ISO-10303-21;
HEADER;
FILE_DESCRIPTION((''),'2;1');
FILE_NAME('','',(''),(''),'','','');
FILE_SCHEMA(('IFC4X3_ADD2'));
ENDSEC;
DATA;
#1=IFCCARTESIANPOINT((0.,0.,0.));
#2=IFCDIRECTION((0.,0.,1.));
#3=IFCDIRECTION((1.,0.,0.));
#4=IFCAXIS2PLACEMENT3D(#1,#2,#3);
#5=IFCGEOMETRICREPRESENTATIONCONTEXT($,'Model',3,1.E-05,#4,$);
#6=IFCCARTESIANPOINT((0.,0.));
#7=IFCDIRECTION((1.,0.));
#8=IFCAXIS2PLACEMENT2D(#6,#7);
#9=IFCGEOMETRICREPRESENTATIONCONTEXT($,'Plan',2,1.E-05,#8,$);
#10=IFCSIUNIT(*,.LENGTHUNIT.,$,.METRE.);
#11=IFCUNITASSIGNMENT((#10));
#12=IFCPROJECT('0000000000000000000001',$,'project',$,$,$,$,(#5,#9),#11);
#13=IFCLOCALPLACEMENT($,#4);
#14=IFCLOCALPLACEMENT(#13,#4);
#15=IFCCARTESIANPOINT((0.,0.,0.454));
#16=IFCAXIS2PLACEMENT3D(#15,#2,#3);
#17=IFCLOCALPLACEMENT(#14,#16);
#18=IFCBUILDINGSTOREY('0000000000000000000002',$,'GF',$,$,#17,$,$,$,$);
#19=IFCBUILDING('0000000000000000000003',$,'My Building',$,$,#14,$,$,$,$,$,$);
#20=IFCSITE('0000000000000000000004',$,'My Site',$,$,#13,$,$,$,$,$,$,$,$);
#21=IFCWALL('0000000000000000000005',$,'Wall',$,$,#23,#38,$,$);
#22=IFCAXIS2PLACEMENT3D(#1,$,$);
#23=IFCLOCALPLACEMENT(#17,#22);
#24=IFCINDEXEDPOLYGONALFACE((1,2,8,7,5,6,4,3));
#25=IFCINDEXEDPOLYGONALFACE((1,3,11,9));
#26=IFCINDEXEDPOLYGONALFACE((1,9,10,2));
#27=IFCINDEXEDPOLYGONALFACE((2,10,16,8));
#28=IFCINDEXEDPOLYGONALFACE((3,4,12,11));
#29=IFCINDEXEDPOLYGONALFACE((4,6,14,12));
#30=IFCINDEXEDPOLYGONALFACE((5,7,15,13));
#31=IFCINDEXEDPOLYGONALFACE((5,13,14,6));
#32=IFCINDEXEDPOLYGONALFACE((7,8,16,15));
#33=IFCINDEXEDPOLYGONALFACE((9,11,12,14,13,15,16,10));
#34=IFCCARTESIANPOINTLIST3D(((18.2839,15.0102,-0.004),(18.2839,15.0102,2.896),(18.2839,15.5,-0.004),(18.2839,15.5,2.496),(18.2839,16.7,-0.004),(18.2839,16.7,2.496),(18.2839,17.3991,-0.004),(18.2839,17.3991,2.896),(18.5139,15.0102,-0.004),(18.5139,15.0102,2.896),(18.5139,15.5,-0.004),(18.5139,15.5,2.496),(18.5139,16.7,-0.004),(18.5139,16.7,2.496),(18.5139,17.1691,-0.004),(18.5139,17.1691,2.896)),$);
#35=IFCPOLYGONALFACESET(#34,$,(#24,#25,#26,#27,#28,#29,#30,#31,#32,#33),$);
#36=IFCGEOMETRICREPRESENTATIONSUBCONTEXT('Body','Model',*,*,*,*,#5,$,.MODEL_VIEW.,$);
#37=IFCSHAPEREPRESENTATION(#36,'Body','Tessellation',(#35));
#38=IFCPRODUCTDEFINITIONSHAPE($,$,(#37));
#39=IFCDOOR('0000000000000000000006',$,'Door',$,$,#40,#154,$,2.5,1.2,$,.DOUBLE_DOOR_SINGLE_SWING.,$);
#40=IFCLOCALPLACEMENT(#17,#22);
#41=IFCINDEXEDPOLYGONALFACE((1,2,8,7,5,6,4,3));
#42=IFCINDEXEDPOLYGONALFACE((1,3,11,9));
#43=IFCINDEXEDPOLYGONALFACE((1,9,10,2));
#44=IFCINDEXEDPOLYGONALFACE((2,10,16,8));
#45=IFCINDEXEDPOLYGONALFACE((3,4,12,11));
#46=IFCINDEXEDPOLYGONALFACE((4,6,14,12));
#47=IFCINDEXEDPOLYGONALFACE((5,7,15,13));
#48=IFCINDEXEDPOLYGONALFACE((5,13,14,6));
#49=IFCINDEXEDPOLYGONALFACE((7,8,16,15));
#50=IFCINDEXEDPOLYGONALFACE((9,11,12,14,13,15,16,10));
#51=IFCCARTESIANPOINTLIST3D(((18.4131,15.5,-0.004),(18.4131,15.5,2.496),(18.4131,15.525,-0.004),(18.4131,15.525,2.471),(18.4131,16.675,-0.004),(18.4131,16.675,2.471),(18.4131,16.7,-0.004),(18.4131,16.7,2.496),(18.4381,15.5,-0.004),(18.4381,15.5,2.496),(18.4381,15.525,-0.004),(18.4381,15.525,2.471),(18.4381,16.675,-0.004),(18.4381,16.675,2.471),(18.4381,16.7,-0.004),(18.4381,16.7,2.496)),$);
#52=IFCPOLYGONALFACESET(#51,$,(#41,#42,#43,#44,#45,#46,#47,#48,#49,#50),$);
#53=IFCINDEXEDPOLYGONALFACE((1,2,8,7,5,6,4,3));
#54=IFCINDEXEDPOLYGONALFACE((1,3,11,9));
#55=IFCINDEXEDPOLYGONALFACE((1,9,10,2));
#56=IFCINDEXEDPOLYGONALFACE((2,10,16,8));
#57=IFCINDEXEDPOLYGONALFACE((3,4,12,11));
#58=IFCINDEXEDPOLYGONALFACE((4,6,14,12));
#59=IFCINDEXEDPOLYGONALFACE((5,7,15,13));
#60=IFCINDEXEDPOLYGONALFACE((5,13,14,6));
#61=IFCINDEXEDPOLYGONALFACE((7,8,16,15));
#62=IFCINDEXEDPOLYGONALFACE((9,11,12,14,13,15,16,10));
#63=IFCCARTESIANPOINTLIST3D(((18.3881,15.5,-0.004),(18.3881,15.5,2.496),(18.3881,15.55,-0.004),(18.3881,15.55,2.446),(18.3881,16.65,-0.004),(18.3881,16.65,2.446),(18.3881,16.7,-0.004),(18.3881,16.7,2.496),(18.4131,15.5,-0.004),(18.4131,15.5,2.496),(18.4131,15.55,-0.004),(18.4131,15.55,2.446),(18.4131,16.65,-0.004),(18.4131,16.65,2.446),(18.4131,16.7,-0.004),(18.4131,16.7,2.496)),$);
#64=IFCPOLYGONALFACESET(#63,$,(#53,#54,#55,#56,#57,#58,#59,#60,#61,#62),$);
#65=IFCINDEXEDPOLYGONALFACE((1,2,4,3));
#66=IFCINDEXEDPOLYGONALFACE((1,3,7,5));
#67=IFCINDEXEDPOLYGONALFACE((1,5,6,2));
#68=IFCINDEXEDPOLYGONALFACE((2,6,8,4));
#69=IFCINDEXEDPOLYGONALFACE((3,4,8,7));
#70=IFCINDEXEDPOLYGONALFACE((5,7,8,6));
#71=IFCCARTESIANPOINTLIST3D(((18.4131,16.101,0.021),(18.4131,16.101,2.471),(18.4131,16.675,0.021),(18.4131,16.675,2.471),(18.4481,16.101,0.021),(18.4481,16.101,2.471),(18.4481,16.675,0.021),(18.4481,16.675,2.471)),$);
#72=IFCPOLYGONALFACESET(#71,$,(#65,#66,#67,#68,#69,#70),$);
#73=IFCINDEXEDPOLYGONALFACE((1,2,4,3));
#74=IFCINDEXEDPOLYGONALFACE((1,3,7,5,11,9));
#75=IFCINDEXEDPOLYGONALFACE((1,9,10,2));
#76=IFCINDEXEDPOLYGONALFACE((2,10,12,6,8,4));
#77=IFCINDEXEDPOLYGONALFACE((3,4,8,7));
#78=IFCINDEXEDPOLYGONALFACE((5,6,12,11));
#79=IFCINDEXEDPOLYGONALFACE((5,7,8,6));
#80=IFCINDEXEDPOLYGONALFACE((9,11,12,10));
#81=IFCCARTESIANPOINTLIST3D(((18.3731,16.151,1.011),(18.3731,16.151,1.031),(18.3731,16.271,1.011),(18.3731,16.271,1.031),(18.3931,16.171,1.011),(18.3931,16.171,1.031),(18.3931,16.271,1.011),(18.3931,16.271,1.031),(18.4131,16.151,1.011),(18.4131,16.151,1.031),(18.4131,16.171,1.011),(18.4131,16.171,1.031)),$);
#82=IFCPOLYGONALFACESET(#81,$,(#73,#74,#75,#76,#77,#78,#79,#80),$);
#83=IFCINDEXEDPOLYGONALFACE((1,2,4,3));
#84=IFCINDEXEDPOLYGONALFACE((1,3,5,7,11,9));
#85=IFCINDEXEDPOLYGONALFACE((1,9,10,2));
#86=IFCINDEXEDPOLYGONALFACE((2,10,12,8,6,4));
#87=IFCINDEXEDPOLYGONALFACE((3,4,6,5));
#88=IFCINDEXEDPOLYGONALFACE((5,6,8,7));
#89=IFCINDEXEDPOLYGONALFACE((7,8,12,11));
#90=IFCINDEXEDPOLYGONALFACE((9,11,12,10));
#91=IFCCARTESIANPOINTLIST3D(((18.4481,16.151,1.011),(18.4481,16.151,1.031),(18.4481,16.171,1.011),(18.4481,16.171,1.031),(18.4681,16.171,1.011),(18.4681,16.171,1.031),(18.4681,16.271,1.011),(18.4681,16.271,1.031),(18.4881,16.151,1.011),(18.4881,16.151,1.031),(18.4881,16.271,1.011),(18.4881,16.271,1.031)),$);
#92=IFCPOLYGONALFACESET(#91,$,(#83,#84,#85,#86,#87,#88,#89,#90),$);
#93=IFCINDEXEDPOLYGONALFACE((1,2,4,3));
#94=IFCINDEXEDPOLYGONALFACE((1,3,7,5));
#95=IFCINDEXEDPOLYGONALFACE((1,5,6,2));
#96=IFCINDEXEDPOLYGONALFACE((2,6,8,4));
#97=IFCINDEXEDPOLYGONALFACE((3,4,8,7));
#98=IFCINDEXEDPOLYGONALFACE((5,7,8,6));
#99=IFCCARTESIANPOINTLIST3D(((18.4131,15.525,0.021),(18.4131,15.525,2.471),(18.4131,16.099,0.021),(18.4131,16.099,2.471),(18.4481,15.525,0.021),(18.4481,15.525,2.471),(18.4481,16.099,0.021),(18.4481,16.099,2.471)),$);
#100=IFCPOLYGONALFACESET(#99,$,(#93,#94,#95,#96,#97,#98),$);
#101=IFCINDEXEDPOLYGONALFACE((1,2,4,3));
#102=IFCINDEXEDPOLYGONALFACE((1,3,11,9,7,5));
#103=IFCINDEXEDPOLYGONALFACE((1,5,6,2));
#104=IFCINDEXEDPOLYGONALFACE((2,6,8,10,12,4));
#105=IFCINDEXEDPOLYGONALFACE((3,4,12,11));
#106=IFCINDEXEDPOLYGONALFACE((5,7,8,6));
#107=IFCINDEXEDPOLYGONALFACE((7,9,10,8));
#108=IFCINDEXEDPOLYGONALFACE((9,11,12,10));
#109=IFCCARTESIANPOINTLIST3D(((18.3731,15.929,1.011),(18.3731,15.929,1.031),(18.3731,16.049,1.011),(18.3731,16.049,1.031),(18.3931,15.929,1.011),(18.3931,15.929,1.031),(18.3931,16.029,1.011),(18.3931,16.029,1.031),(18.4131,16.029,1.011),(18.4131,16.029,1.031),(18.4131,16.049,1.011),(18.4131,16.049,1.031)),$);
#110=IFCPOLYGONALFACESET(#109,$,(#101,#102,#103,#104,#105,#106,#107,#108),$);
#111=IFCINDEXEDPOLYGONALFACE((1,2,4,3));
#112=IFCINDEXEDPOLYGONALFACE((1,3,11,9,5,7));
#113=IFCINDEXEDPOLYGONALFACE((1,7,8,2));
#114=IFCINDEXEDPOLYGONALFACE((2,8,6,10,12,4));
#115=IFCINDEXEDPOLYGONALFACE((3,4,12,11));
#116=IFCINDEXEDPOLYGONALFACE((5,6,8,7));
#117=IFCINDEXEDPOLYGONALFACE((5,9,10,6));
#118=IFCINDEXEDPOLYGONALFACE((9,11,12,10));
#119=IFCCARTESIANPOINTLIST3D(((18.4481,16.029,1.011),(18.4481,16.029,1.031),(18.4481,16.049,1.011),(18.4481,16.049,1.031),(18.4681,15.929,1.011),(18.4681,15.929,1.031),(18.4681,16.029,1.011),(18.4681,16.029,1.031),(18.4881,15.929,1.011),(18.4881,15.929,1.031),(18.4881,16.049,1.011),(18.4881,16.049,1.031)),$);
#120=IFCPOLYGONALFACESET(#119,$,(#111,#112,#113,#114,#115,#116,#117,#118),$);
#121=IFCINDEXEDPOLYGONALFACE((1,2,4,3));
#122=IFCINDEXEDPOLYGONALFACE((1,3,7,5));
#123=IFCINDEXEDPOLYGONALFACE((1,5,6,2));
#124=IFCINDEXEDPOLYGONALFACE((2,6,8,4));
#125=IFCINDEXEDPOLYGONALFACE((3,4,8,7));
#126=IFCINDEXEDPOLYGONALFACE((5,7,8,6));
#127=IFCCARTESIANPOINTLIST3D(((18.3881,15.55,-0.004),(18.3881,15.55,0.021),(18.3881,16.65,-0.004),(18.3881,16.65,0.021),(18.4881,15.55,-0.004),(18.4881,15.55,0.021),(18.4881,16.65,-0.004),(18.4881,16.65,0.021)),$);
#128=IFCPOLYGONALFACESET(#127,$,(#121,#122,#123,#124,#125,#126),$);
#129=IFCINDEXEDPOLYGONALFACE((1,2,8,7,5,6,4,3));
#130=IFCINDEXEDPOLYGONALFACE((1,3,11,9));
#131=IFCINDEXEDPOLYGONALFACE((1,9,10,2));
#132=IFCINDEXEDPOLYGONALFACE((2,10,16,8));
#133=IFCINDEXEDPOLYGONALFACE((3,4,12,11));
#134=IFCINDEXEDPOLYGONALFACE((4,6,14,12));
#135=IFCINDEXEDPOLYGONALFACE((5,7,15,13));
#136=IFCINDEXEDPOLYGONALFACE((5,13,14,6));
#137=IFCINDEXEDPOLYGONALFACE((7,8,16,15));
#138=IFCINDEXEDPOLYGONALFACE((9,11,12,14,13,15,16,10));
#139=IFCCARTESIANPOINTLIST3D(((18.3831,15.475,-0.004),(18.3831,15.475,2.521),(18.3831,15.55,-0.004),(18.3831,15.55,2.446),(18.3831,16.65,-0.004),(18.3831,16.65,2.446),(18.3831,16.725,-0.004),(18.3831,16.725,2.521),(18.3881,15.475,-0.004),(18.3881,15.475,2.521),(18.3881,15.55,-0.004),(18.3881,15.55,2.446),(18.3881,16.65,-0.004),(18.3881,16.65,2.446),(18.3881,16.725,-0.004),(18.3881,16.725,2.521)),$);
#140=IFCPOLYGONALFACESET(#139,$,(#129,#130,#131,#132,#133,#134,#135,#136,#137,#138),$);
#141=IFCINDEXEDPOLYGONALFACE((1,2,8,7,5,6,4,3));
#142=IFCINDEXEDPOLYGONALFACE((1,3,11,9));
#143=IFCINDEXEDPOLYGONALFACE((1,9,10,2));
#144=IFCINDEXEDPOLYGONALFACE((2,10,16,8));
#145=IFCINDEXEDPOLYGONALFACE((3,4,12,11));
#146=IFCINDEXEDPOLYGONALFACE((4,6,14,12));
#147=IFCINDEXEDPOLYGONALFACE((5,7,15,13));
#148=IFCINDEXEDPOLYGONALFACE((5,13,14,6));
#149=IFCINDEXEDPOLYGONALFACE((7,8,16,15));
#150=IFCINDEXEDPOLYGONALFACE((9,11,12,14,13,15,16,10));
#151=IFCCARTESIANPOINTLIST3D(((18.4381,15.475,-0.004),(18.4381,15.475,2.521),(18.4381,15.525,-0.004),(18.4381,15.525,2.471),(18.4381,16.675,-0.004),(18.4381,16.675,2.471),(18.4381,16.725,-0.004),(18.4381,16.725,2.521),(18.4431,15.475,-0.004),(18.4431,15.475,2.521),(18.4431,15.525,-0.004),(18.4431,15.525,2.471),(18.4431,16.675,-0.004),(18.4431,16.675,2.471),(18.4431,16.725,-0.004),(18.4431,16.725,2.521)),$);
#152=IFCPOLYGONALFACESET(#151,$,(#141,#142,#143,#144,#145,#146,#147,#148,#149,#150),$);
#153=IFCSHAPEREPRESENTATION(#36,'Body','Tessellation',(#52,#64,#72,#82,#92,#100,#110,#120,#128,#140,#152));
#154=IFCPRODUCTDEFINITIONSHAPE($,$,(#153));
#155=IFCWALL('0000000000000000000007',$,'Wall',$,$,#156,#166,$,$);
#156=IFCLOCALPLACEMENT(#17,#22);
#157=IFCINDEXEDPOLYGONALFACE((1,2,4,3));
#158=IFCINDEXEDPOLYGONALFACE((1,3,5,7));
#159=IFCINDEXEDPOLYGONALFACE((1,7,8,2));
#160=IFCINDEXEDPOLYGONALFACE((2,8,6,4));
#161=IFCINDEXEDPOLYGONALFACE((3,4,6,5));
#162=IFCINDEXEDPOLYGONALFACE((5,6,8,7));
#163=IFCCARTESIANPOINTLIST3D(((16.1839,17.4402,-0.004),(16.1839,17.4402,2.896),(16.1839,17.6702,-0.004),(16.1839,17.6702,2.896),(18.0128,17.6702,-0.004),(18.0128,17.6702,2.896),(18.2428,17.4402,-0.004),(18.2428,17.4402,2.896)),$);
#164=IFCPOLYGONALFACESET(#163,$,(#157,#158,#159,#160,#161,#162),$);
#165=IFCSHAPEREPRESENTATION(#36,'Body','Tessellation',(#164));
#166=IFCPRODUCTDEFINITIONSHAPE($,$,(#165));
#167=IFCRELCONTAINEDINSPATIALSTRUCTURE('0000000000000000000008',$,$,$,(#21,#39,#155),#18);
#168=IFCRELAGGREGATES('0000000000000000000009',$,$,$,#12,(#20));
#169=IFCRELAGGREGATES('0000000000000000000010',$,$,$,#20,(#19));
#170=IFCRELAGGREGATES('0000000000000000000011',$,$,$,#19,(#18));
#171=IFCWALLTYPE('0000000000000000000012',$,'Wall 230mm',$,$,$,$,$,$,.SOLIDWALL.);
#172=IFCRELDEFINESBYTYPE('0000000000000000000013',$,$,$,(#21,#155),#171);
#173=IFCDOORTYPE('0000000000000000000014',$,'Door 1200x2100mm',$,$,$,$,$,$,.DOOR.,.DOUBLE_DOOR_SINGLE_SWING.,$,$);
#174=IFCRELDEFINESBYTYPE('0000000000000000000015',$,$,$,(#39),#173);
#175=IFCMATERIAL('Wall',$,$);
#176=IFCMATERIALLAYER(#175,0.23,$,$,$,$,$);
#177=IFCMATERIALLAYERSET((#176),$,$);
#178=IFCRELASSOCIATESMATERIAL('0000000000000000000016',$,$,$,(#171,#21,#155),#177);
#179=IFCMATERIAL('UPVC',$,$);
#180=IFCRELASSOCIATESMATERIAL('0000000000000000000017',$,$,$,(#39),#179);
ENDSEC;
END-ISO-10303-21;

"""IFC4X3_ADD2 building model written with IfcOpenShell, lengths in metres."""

from ifc_helpers import new_model, entity, si_unit, frame, origin_with_axes, origin_2d_with_axis, place, context, subcontext, project, spatial, line, indexed_curve, outline, extrude, clip, halfspace, shape, source, transform, mapped, material, layer, layer_set, layer_usage, type_object, type_shapes, element, fill, save


model = new_model("IFC4X3_ADD2")

# Units and contexts
model_context = context("Model", 3, precision=1e-05, world=origin_with_axes())
plan_context = context("Plan", 2, precision=1e-05, world=origin_2d_with_axis())
body_context_1 = subcontext(model_context, "Body", "Model", "MODEL_VIEW")
body_context_2 = subcontext(plan_context, "Body", "Plan", "PLAN_VIEW")
ifc_project = project(units=[si_unit("LENGTHUNIT", "METRE")], contexts=[model_context, plan_context])

# Site, building, storey
site_placement = place(None, origin_with_axes())
site = spatial("IfcSite", under=ifc_project, at=site_placement, Name="My Site")
building_placement = place(site_placement, origin_with_axes())
building = spatial("IfcBuilding", under=site, at=building_placement, Name="My Building")
storey_placement = place(building_placement, frame((0.0, 0.0, 0.454), z_axis=(0.0, 0.0, 1.0), x_axis=(1.0, 0.0, 0.0)))
storey = spatial("IfcBuildingStorey", under=building, at=storey_placement, Name="GF")

# Shared definitions
ifc_material_1 = material(Name="UPVC")

# Shared definitions
ifc_material_2 = material(Name="Wall")

# Shared definitions
ifc_layer_1 = layer(ifc_material_2, 0.23)
ifc_layer_set_1 = layer_set([ifc_layer_1])
wall_type_1 = type_object("IfcWallType", Name="Wall 230mm", PredefinedType="SOLIDWALL", material=ifc_layer_set_1)

# Wall, opening, door
ifc_layer_usage_1 = layer_usage(ifc_layer_set_1, "AXIS2", "POSITIVE", 0.0)
wall_1_placement = place(storey_placement, frame((18.5139, 15.0102, -0.004), z_axis=(0.0, 0.0, 1.0), x_axis=(0.000001, 1.0, 0.0)))
wall_1 = element("IfcWall", 1, at=wall_1_placement, inside=storey, type_object=wall_type_1, material=ifc_layer_usage_1, Name="Wall", context=body_context_1, shape_type="Clipping", body=[
    clip(extrude(outline(indexed_curve([(0.0, 0.0), (0.0, 0.23), (2.3889, 0.23), (2.3889, 0.0), (0.0, 0.0)], self_intersect=False)), origin_with_axes(), (0.0, 0.0, 1.0), 2.9), halfspace(frame((2.1589, 0.0, -0.45), z_axis=(0.666999, -0.666993, 0.0), x_axis=(-0.707103, -0.70711, 0.0)), False)),
])
shared_shape_1 = source(origin_with_axes(), body_context_1, "Body", "SweptSolid", [
    extrude(outline(indexed_curve([(0.0, 0.0), (1.2, 0.0), (1.2, 2.5), (0.0, 2.5)], segments=[line(1, 2, 3, 4, 1)])), frame((0.0, -0.6, 0.0), z_axis=(0.0, -1.0, 0.0), x_axis=(1.0, 0.0, 0.0)), (0.0, 0.0, -1.0), 1.2),
])
opening_1_placement = place(wall_1_placement, frame((1.6898, 0.1258, 0.0), z_axis=(0.0, 0.0, 1.0), x_axis=(-1.0, 0.0, 0.0)))
opening_1 = element("IfcOpeningElement", 2, at=opening_1_placement, cuts=wall_1, PredefinedType="OPENING", context=body_context_1, shape_type="MappedRepresentation", body=[
    mapped(shared_shape_1, transform((0.0, 0.0, 0.0), x_axis=(1.0, 0.0, 0.0), y_axis=(0.0, 1.0, 0.0), z_axis=(0.0, 0.0, 1.0), scale=1.0)),
])
door_type_1 = type_object("IfcDoorType", Name="Door 1200x2100mm", OperationType="DOUBLE_DOOR_SINGLE_SWING", PredefinedType="DOOR")
shared_shape_2 = source(origin_with_axes(), body_context_1, "Body", "SweptSolid", [
    extrude(outline(indexed_curve([(0.0, 0.0), (0.0, 2.5), (1.2, 2.5), (1.2, 0.0), (1.175, 0.0), (1.175, 2.475), (0.025, 2.475), (0.025, 0.0)], segments=[line(1, 2, 3, 4, 5, 6, 7, 8, 1)])), frame((0.0, 0.025, 0.0), z_axis=(0.0, -1.0, 0.0), x_axis=(1.0, 0.0, 0.0)), (0.0, 0.0, -1.0), 0.025),
    extrude(outline(indexed_curve([(0.0, 0.0), (0.0, 2.5), (1.2, 2.5), (1.2, 0.0), (1.15, 0.0), (1.15, 2.45), (0.05, 2.45), (0.05, 0.0)], segments=[line(1, 2, 3, 4, 5, 6, 7, 8, 1)])), frame((0.0, 0.0, 0.0), z_axis=(0.0, -1.0, 0.0), x_axis=(1.0, 0.0, 0.0)), (0.0, 0.0, -1.0), 0.025),
    extrude(outline(indexed_curve([(0.0, 0.0), (0.574, 0.0), (0.574, 0.035), (0.0, 0.035)], segments=[line(1, 2, 3, 4, 1)])), frame((0.025, 0.025, 0.025), z_axis=(0.0, 0.0, 1.0), x_axis=(1.0, 0.0, 0.0)), (0.0, 0.0, 1.0), 2.45),
    extrude(outline(indexed_curve([(0.0, 0.0), (0.0, -0.04), (-0.12, -0.04), (-0.12, -0.02), (-0.02, -0.02), (-0.02, 0.0)], segments=[line(1, 2, 3, 4, 5, 6, 1)])), frame((0.549, 0.025, 1.015), z_axis=(0.0, 0.0, 1.0), x_axis=(1.0, 0.0, 0.0)), (0.0, 0.0, 1.0), 0.02),
    extrude(outline(indexed_curve([(0.0, 0.0), (0.0, 0.04), (-0.12, 0.04), (-0.12, 0.02), (-0.02, 0.02), (-0.02, 0.0)], segments=[line(1, 2, 3, 4, 5, 6, 1)])), frame((0.549, 0.06, 1.015), z_axis=(0.0, 0.0, 1.0), x_axis=(1.0, 0.0, 0.0)), (0.0, 0.0, 1.0), 0.02),
    extrude(outline(indexed_curve([(0.0, 0.0), (-0.574, 0.0), (-0.574, 0.035), (0.0, 0.035)], segments=[line(1, 2, 3, 4, 1)])), frame((1.175, 0.025, 0.025), z_axis=(0.0, 0.0, 1.0), x_axis=(1.0, 0.0, 0.0)), (0.0, 0.0, 1.0), 2.45),
    extrude(outline(indexed_curve([(0.0, 0.0), (0.0, -0.04), (0.12, -0.04), (0.12, -0.02), (0.02, -0.02), (0.02, 0.0)], segments=[line(1, 2, 3, 4, 5, 6, 1)])), frame((0.651, 0.025, 1.015), z_axis=(0.0, 0.0, 1.0), x_axis=(1.0, 0.0, 0.0)), (0.0, 0.0, 1.0), 0.02),
    extrude(outline(indexed_curve([(0.0, 0.0), (0.0, 0.04), (0.12, 0.04), (0.12, 0.02), (0.02, 0.02), (0.02, 0.0)], segments=[line(1, 2, 3, 4, 5, 6, 1)])), frame((0.651, 0.06, 1.015), z_axis=(0.0, 0.0, 1.0), x_axis=(1.0, 0.0, 0.0)), (0.0, 0.0, 1.0), 0.02),
    extrude(outline(indexed_curve([(0.0, 0.0), (1.1, 0.0), (1.1, 0.1), (0.0, 0.1)], segments=[line(1, 2, 3, 4, 1)])), frame((0.05, 0.0, 0.0), z_axis=(0.0, 0.0, 1.0), x_axis=(1.0, 0.0, 0.0)), (0.0, 0.0, 1.0), 0.025),
    extrude(outline(indexed_curve([(0.0, 0.0), (0.0, 2.525), (1.25, 2.525), (1.25, 0.0), (1.175, 0.0), (1.175, 2.45), (0.075, 2.45), (0.075, 0.0)], segments=[line(1, 2, 3, 4, 5, 6, 7, 8, 1)])), frame((-0.025, -0.005, 0.0), z_axis=(0.0, -1.0, 0.0), x_axis=(1.0, 0.0, 0.0)), (0.0, 0.0, -1.0), 0.005),
    extrude(outline(indexed_curve([(0.0, 0.0), (0.0, 2.525), (1.25, 2.525), (1.25, 0.0), (1.2, 0.0), (1.2, 2.475), (0.05, 2.475), (0.05, 0.0)], segments=[line(1, 2, 3, 4, 5, 6, 7, 8, 1)])), frame((-0.025, 0.05, 0.0), z_axis=(0.0, -1.0, 0.0), x_axis=(1.0, 0.0, 0.0)), (0.0, 0.0, -1.0), 0.005),
])
shared_shape_3 = source(origin_with_axes(), body_context_2, "Body", "Curve2D", [
    entity("IfcIndexedPolyCurve", entity("IfcCartesianPointList2D", [[0.0, 0.0], [0.0, 0.05], [0.025, 0.05], [0.025, 0.025], [0.05, 0.025], [0.05, 0.0]]), [entity("IfcLineIndex", [1, 2, 3, 4, 5, 6, 1])]),
    entity("IfcIndexedPolyCurve", entity("IfcCartesianPointList2D", [[1.2, 0.0], [1.2, 0.05], [1.175, 0.05], [1.175, 0.025], [1.15, 0.025], [1.15, 0.0]]), [entity("IfcLineIndex", [1, 2, 3, 4, 5, 6, 1])]),
    entity("IfcTrimmedCurve", entity("IfcEllipse", entity("IfcAxis2Placement2D", entity("IfcCartesianPoint", [0.06, 0.05]), entity("IfcDirection", [1.0, 0.0])), 0.54, 0.575), [entity("IfcCartesianPoint", [0.6, 0.05])], [entity("IfcCartesianPoint", [0.06, 0.625])], True, "CARTESIAN"),
    entity("IfcIndexedPolyCurve", entity("IfcCartesianPointList2D", [[0.025, 0.05], [0.06, 0.05], [0.06, 0.625], [0.025, 0.625]]), [entity("IfcLineIndex", [1, 2, 3, 4, 1])]),
    entity("IfcTrimmedCurve", entity("IfcEllipse", entity("IfcAxis2Placement2D", entity("IfcCartesianPoint", [1.14, 0.05]), entity("IfcDirection", [1.0, 0.0])), 0.54, 0.575), [entity("IfcCartesianPoint", [1.14, 0.625])], [entity("IfcCartesianPoint", [0.6, 0.05])], True, "CARTESIAN"),
    entity("IfcIndexedPolyCurve", entity("IfcCartesianPointList2D", [[1.175, 0.05], [1.14, 0.05], [1.14, 0.625], [1.175, 0.625]]), [entity("IfcLineIndex", [1, 2, 3, 4, 1])]),
])
type_shapes(door_type_1, [shared_shape_2, shared_shape_3])
door_1_placement = place(opening_1_placement, frame((0.0, 0.0, 0.0), z_axis=(0.0, 0.0, 1.0), x_axis=(1.0, 0.0, 0.0)))
door_1 = element("IfcDoor", 3, at=door_1_placement, inside=storey, type_object=door_type_1, material=ifc_material_1, Name="Door", OperationType="DOUBLE_DOOR_SINGLE_SWING", OverallHeight=2.5, OverallWidth=1.2, shapes=[
    shape(body_context_1, "Body", "MappedRepresentation", [mapped(shared_shape_2, transform((0.0, 0.0, 0.0), x_axis=(1.0, 0.0, 0.0), y_axis=(0.0, 1.0, 0.0), z_axis=(0.0, 0.0, 1.0), scale=1.0))]),
    shape(body_context_2, "Body", "MappedRepresentation", [mapped(shared_shape_3, transform((0.0, 0.0, 0.0), x_axis=(1.0, 0.0, 0.0), y_axis=(0.0, 1.0, 0.0), z_axis=(0.0, 0.0, 1.0), scale=1.0))]),
])
fill(opening_1, door_1)

# Wall
ifc_layer_usage_2 = layer_usage(ifc_layer_set_1, "AXIS2", "POSITIVE", 0.0)
wall_2_placement = place(storey_placement, frame((18.2428, 17.6702, -0.004), z_axis=(0.0, 0.0, 1.0), x_axis=(-1.0, 0.0, 0.0)))
element("IfcWall", 4, at=wall_2_placement, inside=storey, type_object=wall_type_1, material=ifc_layer_usage_2, Name="Wall", context=body_context_1, shape_type="Clipping", body=[
    clip(extrude(outline(indexed_curve([(0.0, 0.0), (0.0, 0.23), (2.0589, 0.23), (2.0589, 0.0), (0.0, 0.0)], self_intersect=False)), origin_with_axes(), (0.0, 0.0, 1.0), 2.9), halfspace(frame((0.23, 0.0, -0.45), z_axis=(-0.666999, -0.666999, 0.0), x_axis=(-0.707107, 0.707107, 0.0)), False)),
])

save(model, "model.ifc")
